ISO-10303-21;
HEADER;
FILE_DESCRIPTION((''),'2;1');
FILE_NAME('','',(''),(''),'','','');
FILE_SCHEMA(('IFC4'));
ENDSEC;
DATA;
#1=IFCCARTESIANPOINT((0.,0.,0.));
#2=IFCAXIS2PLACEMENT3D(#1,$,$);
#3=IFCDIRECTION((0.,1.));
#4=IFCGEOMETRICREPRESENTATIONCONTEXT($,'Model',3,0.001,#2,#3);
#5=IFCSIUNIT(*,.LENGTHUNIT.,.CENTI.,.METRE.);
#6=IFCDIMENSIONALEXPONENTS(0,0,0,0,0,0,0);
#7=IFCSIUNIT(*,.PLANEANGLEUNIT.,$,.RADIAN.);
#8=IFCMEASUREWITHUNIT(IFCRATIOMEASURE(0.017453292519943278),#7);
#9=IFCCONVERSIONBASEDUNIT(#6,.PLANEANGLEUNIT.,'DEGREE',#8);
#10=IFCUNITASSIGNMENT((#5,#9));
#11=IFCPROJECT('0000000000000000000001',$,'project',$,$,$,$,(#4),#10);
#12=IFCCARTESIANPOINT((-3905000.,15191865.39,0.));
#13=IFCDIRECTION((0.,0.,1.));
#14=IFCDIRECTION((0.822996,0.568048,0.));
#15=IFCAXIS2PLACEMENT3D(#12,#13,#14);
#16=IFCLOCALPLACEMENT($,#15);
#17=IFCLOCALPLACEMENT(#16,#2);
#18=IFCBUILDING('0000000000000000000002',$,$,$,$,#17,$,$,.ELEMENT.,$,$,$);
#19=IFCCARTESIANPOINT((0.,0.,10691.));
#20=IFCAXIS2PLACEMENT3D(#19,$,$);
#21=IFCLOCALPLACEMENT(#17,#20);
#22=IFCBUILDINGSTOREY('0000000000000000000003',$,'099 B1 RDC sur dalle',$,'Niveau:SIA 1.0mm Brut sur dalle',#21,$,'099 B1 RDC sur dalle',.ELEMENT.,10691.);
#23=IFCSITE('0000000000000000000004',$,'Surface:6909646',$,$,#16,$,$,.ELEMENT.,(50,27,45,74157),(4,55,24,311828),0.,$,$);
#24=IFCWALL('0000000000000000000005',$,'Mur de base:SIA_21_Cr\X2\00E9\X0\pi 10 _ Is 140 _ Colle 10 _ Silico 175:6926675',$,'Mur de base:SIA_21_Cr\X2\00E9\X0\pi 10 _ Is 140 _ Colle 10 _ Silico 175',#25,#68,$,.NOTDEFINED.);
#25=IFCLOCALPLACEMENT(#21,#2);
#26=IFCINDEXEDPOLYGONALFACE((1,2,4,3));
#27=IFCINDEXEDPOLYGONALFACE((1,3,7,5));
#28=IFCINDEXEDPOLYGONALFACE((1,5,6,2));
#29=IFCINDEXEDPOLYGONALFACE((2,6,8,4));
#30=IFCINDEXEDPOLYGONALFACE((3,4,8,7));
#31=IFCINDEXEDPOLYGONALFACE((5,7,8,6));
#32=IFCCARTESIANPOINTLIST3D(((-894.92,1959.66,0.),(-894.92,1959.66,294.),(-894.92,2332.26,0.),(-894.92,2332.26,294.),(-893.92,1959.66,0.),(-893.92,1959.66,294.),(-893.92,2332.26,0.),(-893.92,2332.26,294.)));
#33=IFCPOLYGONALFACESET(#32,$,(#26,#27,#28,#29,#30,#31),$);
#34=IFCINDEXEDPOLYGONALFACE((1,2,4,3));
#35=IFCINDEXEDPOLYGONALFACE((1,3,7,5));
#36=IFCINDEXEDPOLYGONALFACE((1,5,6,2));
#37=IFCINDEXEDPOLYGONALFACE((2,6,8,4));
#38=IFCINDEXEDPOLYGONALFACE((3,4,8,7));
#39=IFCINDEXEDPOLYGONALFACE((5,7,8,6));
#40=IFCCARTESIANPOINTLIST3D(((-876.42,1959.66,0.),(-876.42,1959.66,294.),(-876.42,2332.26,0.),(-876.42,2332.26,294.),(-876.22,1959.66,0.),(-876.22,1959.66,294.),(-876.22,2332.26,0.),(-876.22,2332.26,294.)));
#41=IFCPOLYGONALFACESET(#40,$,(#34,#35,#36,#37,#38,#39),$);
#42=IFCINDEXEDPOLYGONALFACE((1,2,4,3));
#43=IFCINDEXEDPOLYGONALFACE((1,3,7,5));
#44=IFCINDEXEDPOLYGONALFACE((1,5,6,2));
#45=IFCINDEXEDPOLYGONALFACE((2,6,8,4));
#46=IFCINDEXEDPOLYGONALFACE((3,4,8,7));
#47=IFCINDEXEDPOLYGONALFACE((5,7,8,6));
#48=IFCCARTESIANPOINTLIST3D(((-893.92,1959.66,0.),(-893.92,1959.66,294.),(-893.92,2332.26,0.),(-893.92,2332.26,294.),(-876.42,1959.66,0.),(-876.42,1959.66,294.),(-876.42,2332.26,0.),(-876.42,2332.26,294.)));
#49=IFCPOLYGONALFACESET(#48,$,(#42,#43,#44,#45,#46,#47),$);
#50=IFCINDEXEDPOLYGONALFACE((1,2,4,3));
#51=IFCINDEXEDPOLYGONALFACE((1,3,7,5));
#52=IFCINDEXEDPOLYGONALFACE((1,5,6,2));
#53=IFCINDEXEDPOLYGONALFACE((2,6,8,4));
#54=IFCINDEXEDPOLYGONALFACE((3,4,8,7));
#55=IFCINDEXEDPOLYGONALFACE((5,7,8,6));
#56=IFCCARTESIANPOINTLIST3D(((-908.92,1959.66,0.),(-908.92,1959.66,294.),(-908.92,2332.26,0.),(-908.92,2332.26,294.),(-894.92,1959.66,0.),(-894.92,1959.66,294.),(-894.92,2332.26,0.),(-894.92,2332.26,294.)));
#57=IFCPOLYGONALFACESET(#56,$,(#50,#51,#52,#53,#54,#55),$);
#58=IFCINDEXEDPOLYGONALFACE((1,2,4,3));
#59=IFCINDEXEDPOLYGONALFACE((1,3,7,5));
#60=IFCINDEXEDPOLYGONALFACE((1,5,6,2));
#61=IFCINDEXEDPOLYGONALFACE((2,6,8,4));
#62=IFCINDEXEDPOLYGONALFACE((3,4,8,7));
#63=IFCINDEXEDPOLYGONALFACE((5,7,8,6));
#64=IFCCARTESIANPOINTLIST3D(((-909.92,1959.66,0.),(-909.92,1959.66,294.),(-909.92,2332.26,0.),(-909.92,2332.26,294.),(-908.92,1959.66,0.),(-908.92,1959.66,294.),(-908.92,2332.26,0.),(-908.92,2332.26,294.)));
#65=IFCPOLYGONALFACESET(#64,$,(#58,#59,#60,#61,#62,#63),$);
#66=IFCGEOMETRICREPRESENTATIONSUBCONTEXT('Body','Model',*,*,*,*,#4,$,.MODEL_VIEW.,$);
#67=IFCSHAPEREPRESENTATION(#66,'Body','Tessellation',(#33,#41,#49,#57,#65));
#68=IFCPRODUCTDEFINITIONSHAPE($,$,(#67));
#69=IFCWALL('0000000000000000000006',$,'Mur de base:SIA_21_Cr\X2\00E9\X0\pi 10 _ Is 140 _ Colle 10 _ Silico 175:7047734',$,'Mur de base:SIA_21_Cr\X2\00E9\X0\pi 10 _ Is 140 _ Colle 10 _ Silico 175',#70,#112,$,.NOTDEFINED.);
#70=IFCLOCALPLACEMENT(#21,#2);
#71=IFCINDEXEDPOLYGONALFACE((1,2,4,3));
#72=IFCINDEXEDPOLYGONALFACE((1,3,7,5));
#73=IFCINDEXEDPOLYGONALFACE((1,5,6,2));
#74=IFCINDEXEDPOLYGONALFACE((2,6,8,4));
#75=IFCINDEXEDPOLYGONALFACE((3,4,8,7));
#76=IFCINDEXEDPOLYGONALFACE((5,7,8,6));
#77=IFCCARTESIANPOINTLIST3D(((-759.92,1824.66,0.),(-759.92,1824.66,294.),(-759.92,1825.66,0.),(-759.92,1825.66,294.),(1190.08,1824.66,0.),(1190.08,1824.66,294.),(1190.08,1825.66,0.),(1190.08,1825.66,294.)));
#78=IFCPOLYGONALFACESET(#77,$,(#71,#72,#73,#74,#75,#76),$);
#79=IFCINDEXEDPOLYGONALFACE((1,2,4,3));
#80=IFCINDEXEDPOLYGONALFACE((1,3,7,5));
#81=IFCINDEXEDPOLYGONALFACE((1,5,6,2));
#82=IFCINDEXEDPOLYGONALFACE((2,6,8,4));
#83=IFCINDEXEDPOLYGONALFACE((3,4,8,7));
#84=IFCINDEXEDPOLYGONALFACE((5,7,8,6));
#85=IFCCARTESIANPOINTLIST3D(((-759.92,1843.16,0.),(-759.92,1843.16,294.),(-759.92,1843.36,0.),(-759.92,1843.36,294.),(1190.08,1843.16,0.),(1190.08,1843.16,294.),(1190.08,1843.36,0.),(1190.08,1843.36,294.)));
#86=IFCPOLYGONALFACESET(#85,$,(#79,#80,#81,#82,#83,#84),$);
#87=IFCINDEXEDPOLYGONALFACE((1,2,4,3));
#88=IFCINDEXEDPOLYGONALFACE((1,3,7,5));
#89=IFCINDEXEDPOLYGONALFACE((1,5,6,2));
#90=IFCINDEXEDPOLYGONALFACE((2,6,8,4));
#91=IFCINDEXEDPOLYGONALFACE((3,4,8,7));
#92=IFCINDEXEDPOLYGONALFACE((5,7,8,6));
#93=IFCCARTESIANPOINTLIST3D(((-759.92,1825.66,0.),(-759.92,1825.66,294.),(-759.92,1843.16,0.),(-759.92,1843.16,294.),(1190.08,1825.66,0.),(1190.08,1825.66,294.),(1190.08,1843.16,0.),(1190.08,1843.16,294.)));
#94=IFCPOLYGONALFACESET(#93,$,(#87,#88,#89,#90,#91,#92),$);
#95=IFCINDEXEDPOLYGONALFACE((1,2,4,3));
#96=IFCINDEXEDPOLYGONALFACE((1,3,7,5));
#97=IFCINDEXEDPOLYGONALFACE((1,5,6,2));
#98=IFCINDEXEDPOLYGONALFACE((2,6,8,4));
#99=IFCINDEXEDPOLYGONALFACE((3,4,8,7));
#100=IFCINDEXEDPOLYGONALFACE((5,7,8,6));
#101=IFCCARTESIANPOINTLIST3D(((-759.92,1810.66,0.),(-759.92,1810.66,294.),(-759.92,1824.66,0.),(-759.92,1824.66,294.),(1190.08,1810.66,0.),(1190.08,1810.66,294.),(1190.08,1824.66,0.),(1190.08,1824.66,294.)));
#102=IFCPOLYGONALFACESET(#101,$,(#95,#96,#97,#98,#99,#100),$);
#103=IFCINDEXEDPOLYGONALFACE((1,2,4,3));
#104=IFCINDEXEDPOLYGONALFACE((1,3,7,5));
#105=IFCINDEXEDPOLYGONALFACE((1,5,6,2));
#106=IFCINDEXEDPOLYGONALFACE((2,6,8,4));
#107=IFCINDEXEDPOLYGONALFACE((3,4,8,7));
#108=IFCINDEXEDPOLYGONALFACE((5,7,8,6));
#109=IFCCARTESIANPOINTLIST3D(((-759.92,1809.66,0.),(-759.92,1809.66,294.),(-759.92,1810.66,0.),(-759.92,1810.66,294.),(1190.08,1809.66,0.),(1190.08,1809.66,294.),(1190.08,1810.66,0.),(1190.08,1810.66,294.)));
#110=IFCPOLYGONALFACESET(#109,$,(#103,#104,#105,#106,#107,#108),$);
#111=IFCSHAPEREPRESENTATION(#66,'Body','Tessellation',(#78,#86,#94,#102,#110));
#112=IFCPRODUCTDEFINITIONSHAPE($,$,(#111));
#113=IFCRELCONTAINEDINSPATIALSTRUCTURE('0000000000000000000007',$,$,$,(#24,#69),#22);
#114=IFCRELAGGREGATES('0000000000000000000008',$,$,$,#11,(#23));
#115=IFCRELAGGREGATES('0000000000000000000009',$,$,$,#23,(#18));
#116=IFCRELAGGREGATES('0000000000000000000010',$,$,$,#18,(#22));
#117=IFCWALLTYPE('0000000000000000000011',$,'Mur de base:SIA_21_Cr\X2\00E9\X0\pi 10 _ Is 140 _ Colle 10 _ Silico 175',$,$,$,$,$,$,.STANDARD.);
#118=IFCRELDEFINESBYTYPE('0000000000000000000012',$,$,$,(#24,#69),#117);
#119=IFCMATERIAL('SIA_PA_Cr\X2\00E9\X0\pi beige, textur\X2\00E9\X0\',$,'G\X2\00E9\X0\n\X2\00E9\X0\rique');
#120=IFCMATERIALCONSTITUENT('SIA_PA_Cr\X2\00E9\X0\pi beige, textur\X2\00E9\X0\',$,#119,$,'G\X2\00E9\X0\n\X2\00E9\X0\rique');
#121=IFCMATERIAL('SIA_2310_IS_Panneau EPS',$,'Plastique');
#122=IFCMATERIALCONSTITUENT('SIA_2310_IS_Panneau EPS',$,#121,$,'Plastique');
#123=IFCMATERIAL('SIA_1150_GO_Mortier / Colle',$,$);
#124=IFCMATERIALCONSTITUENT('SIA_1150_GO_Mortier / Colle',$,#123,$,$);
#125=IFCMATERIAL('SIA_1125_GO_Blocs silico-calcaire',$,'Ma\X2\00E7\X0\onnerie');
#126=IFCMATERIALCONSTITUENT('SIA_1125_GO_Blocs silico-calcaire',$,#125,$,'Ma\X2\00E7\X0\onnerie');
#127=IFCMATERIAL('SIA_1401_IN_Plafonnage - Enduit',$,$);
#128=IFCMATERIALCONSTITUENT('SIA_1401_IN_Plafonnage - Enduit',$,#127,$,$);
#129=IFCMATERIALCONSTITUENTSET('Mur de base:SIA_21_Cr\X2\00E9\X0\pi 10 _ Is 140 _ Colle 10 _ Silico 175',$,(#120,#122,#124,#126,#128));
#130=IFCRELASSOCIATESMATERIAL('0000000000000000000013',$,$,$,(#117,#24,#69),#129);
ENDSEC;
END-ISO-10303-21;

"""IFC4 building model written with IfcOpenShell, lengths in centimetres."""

from ifc_helpers import new_model, entity, si_unit, converted_unit, direction, frame, origin, place, context, subcontext, project, spatial, indexed_curve, outline, extrude, material, constituent, constituent_set, type_object, element, save


model = new_model("IFC4")

# Units and contexts
model_context = context("Model", 3, precision=0.001, world=origin(), true_north=direction((0.0, 1.0)))
body_context = subcontext(model_context, "Body", "Model", "MODEL_VIEW")
ifc_project = project(units=[si_unit("LENGTHUNIT", "METRE", prefix="CENTI"), converted_unit("PLANEANGLEUNIT", "DEGREE", entity("IfcRatioMeasure", 0.017453292519943278), si_unit("PLANEANGLEUNIT", "RADIAN"), dimensions=[0, 0, 0, 0, 0, 0, 0])], contexts=[model_context])

# Site, building, storey
site_placement = place(None, frame((-3905000.0, 15191865.39, 0.0), z_axis=(0.0, 0.0, 1.0), x_axis=(0.822996, 0.568048, 0.0)))
site = spatial("IfcSite", under=ifc_project, at=site_placement, Name="Surface:6909646", CompositionType="ELEMENT", RefLatitude=(50, 27, 45, 74157), RefLongitude=(4, 55, 24, 311828), RefElevation=0.0)
building_placement = place(site_placement, origin())
building = spatial("IfcBuilding", under=site, at=building_placement, CompositionType="ELEMENT")
storey_placement = place(building_placement, frame((0.0, 0.0, 10691.0)))
storey = spatial("IfcBuildingStorey", under=building, at=storey_placement, Name="099 B1 RDC sur dalle", ObjectType="Niveau:SIA 1.0mm Brut sur dalle", LongName="099 B1 RDC sur dalle", CompositionType="ELEMENT", Elevation=10691.0)

# Walls
ifc_material_1 = material(Name="SIA_PA_Crépi beige, texturé", Category="Générique")
ifc_constituent_1 = constituent(ifc_material_1, Name="SIA_PA_Crépi beige, texturé", Category="Générique")
ifc_material_2 = material(Name="SIA_2310_IS_Panneau EPS", Category="Plastique")
ifc_constituent_2 = constituent(ifc_material_2, Name="SIA_2310_IS_Panneau EPS", Category="Plastique")
ifc_material_3 = material(Name="SIA_1150_GO_Mortier / Colle")
ifc_constituent_3 = constituent(ifc_material_3, Name="SIA_1150_GO_Mortier / Colle")
ifc_material_4 = material(Name="SIA_1125_GO_Blocs silico-calcaire", Category="Maçonnerie")
ifc_constituent_4 = constituent(ifc_material_4, Name="SIA_1125_GO_Blocs silico-calcaire", Category="Maçonnerie")
ifc_material_5 = material(Name="SIA_1401_IN_Plafonnage - Enduit")
ifc_constituent_5 = constituent(ifc_material_5, Name="SIA_1401_IN_Plafonnage - Enduit")
ifc_constituent_set = constituent_set(constituents=[ifc_constituent_1, ifc_constituent_2, ifc_constituent_3, ifc_constituent_4, ifc_constituent_5], Name="Mur de base:SIA_21_Crépi 10 _ Is 140 _ Colle 10 _ Silico 175")
wall_type_1 = type_object("IfcWallType", Name="Mur de base:SIA_21_Crépi 10 _ Is 140 _ Colle 10 _ Silico 175", PredefinedType="STANDARD", material=ifc_constituent_set)
wall_1_placement = place(storey_placement, frame((-893.07, 1959.66, 0.0), z_axis=(0.0, 0.0, 1.0), x_axis=(0.0, 1.0, 0.0)))
element("IfcWall", 1, at=wall_1_placement, inside=storey, type_object=wall_type_1, material=ifc_constituent_set, Name="Mur de base:SIA_21_Crépi 10 _ Is 140 _ Colle 10 _ Silico 175:6926675", ObjectType="Mur de base:SIA_21_Crépi 10 _ Is 140 _ Colle 10 _ Silico 175", PredefinedType="NOTDEFINED", context=body_context, shape_type="SweptSolid", body=[
    extrude(outline(indexed_curve([(-147.0, -186.3), (147.0, -186.3), (147.0, 186.3), (-147.0, 186.3), (-147.0, -186.3)], self_intersect=False)), frame((186.3, 1.85, 147.0), z_axis=(0.0, -1.0, 0.0), x_axis=(0.0, 0.0, 1.0)), (0.0, 0.0, 1.0), 1.0),
    extrude(outline(indexed_curve([(-147.0, -186.3), (147.0, -186.3), (147.0, 186.3), (-147.0, 186.3), (-147.0, -186.3)], self_intersect=False)), frame((186.3, -16.65, 147.0), z_axis=(0.0, -1.0, 0.0), x_axis=(0.0, 0.0, 1.0)), (0.0, 0.0, 1.0), 0.2),
    extrude(outline(indexed_curve([(-147.0, -186.3), (147.0, -186.3), (147.0, 186.3), (-147.0, 186.3), (-147.0, -186.3)], self_intersect=False)), frame((186.3, 0.85, 147.0), z_axis=(0.0, -1.0, 0.0), x_axis=(0.0, 0.0, 1.0)), (0.0, 0.0, 1.0), 17.5),
    extrude(outline(indexed_curve([(-147.0, -186.3), (147.0, -186.3), (147.0, 186.3), (-147.0, 186.3), (-147.0, -186.3)], self_intersect=False)), frame((186.3, 15.85, 147.0), z_axis=(0.0, -1.0, 0.0), x_axis=(0.0, 0.0, 1.0)), (0.0, 0.0, 1.0), 14.0),
    extrude(outline(indexed_curve([(-186.3, -147.0), (186.3, -147.0), (186.3, 147.0), (-186.3, 147.0), (-186.3, -147.0)], self_intersect=False)), frame((186.3, 16.85, 147.0), z_axis=(0.0, -1.0, 0.0), x_axis=(1.0, 0.0, 0.0)), (0.0, 0.0, 1.0), 1.0),
])
wall_2_placement = place(storey_placement, frame((-759.92, 1826.51, 0.0)))
element("IfcWall", 2, at=wall_2_placement, inside=storey, type_object=wall_type_1, material=ifc_constituent_set, Name="Mur de base:SIA_21_Crépi 10 _ Is 140 _ Colle 10 _ Silico 175:7047734", ObjectType="Mur de base:SIA_21_Crépi 10 _ Is 140 _ Colle 10 _ Silico 175", PredefinedType="NOTDEFINED", context=body_context, shape_type="SweptSolid", body=[
    extrude(outline(indexed_curve([(-975.0, -0.5), (975.0, -0.5), (975.0, 0.5), (-975.0, 0.5), (-975.0, -0.5)], self_intersect=False)), frame((975.0, -1.35, 0.0)), (0.0, 0.0, 1.0), 294.0),
    extrude(outline(indexed_curve([(-0.1, -975.0), (0.1, -975.0), (0.1, 975.0), (-0.1, 975.0), (-0.1, -975.0)], self_intersect=False)), frame((975.0, 16.75, 0.0), z_axis=(0.0, 0.0, 1.0), x_axis=(0.0, -1.0, 0.0)), (0.0, 0.0, 1.0), 294.0),
    extrude(outline(indexed_curve([(-975.0, -8.75), (975.0, -8.75), (975.0, 8.75), (-975.0, 8.75), (-975.0, -8.75)], self_intersect=False)), frame((975.0, 7.9, 0.0)), (0.0, 0.0, 1.0), 294.0),
    extrude(outline(indexed_curve([(-975.0, -7.0), (975.0, -7.0), (975.0, 7.0), (-975.0, 7.0), (-975.0, -7.0)], self_intersect=False)), frame((975.0, -8.85, 0.0)), (0.0, 0.0, 1.0), 294.0),
    extrude(outline(indexed_curve([(-0.5, -975.0), (0.5, -975.0), (0.5, 975.0), (-0.5, 975.0), (-0.5, -975.0)], self_intersect=False)), frame((975.0, -16.35, 0.0), z_axis=(0.0, 0.0, 1.0), x_axis=(0.0, 1.0, 0.0)), (0.0, 0.0, 1.0), 294.0),
])

save(model, "model.ifc")
